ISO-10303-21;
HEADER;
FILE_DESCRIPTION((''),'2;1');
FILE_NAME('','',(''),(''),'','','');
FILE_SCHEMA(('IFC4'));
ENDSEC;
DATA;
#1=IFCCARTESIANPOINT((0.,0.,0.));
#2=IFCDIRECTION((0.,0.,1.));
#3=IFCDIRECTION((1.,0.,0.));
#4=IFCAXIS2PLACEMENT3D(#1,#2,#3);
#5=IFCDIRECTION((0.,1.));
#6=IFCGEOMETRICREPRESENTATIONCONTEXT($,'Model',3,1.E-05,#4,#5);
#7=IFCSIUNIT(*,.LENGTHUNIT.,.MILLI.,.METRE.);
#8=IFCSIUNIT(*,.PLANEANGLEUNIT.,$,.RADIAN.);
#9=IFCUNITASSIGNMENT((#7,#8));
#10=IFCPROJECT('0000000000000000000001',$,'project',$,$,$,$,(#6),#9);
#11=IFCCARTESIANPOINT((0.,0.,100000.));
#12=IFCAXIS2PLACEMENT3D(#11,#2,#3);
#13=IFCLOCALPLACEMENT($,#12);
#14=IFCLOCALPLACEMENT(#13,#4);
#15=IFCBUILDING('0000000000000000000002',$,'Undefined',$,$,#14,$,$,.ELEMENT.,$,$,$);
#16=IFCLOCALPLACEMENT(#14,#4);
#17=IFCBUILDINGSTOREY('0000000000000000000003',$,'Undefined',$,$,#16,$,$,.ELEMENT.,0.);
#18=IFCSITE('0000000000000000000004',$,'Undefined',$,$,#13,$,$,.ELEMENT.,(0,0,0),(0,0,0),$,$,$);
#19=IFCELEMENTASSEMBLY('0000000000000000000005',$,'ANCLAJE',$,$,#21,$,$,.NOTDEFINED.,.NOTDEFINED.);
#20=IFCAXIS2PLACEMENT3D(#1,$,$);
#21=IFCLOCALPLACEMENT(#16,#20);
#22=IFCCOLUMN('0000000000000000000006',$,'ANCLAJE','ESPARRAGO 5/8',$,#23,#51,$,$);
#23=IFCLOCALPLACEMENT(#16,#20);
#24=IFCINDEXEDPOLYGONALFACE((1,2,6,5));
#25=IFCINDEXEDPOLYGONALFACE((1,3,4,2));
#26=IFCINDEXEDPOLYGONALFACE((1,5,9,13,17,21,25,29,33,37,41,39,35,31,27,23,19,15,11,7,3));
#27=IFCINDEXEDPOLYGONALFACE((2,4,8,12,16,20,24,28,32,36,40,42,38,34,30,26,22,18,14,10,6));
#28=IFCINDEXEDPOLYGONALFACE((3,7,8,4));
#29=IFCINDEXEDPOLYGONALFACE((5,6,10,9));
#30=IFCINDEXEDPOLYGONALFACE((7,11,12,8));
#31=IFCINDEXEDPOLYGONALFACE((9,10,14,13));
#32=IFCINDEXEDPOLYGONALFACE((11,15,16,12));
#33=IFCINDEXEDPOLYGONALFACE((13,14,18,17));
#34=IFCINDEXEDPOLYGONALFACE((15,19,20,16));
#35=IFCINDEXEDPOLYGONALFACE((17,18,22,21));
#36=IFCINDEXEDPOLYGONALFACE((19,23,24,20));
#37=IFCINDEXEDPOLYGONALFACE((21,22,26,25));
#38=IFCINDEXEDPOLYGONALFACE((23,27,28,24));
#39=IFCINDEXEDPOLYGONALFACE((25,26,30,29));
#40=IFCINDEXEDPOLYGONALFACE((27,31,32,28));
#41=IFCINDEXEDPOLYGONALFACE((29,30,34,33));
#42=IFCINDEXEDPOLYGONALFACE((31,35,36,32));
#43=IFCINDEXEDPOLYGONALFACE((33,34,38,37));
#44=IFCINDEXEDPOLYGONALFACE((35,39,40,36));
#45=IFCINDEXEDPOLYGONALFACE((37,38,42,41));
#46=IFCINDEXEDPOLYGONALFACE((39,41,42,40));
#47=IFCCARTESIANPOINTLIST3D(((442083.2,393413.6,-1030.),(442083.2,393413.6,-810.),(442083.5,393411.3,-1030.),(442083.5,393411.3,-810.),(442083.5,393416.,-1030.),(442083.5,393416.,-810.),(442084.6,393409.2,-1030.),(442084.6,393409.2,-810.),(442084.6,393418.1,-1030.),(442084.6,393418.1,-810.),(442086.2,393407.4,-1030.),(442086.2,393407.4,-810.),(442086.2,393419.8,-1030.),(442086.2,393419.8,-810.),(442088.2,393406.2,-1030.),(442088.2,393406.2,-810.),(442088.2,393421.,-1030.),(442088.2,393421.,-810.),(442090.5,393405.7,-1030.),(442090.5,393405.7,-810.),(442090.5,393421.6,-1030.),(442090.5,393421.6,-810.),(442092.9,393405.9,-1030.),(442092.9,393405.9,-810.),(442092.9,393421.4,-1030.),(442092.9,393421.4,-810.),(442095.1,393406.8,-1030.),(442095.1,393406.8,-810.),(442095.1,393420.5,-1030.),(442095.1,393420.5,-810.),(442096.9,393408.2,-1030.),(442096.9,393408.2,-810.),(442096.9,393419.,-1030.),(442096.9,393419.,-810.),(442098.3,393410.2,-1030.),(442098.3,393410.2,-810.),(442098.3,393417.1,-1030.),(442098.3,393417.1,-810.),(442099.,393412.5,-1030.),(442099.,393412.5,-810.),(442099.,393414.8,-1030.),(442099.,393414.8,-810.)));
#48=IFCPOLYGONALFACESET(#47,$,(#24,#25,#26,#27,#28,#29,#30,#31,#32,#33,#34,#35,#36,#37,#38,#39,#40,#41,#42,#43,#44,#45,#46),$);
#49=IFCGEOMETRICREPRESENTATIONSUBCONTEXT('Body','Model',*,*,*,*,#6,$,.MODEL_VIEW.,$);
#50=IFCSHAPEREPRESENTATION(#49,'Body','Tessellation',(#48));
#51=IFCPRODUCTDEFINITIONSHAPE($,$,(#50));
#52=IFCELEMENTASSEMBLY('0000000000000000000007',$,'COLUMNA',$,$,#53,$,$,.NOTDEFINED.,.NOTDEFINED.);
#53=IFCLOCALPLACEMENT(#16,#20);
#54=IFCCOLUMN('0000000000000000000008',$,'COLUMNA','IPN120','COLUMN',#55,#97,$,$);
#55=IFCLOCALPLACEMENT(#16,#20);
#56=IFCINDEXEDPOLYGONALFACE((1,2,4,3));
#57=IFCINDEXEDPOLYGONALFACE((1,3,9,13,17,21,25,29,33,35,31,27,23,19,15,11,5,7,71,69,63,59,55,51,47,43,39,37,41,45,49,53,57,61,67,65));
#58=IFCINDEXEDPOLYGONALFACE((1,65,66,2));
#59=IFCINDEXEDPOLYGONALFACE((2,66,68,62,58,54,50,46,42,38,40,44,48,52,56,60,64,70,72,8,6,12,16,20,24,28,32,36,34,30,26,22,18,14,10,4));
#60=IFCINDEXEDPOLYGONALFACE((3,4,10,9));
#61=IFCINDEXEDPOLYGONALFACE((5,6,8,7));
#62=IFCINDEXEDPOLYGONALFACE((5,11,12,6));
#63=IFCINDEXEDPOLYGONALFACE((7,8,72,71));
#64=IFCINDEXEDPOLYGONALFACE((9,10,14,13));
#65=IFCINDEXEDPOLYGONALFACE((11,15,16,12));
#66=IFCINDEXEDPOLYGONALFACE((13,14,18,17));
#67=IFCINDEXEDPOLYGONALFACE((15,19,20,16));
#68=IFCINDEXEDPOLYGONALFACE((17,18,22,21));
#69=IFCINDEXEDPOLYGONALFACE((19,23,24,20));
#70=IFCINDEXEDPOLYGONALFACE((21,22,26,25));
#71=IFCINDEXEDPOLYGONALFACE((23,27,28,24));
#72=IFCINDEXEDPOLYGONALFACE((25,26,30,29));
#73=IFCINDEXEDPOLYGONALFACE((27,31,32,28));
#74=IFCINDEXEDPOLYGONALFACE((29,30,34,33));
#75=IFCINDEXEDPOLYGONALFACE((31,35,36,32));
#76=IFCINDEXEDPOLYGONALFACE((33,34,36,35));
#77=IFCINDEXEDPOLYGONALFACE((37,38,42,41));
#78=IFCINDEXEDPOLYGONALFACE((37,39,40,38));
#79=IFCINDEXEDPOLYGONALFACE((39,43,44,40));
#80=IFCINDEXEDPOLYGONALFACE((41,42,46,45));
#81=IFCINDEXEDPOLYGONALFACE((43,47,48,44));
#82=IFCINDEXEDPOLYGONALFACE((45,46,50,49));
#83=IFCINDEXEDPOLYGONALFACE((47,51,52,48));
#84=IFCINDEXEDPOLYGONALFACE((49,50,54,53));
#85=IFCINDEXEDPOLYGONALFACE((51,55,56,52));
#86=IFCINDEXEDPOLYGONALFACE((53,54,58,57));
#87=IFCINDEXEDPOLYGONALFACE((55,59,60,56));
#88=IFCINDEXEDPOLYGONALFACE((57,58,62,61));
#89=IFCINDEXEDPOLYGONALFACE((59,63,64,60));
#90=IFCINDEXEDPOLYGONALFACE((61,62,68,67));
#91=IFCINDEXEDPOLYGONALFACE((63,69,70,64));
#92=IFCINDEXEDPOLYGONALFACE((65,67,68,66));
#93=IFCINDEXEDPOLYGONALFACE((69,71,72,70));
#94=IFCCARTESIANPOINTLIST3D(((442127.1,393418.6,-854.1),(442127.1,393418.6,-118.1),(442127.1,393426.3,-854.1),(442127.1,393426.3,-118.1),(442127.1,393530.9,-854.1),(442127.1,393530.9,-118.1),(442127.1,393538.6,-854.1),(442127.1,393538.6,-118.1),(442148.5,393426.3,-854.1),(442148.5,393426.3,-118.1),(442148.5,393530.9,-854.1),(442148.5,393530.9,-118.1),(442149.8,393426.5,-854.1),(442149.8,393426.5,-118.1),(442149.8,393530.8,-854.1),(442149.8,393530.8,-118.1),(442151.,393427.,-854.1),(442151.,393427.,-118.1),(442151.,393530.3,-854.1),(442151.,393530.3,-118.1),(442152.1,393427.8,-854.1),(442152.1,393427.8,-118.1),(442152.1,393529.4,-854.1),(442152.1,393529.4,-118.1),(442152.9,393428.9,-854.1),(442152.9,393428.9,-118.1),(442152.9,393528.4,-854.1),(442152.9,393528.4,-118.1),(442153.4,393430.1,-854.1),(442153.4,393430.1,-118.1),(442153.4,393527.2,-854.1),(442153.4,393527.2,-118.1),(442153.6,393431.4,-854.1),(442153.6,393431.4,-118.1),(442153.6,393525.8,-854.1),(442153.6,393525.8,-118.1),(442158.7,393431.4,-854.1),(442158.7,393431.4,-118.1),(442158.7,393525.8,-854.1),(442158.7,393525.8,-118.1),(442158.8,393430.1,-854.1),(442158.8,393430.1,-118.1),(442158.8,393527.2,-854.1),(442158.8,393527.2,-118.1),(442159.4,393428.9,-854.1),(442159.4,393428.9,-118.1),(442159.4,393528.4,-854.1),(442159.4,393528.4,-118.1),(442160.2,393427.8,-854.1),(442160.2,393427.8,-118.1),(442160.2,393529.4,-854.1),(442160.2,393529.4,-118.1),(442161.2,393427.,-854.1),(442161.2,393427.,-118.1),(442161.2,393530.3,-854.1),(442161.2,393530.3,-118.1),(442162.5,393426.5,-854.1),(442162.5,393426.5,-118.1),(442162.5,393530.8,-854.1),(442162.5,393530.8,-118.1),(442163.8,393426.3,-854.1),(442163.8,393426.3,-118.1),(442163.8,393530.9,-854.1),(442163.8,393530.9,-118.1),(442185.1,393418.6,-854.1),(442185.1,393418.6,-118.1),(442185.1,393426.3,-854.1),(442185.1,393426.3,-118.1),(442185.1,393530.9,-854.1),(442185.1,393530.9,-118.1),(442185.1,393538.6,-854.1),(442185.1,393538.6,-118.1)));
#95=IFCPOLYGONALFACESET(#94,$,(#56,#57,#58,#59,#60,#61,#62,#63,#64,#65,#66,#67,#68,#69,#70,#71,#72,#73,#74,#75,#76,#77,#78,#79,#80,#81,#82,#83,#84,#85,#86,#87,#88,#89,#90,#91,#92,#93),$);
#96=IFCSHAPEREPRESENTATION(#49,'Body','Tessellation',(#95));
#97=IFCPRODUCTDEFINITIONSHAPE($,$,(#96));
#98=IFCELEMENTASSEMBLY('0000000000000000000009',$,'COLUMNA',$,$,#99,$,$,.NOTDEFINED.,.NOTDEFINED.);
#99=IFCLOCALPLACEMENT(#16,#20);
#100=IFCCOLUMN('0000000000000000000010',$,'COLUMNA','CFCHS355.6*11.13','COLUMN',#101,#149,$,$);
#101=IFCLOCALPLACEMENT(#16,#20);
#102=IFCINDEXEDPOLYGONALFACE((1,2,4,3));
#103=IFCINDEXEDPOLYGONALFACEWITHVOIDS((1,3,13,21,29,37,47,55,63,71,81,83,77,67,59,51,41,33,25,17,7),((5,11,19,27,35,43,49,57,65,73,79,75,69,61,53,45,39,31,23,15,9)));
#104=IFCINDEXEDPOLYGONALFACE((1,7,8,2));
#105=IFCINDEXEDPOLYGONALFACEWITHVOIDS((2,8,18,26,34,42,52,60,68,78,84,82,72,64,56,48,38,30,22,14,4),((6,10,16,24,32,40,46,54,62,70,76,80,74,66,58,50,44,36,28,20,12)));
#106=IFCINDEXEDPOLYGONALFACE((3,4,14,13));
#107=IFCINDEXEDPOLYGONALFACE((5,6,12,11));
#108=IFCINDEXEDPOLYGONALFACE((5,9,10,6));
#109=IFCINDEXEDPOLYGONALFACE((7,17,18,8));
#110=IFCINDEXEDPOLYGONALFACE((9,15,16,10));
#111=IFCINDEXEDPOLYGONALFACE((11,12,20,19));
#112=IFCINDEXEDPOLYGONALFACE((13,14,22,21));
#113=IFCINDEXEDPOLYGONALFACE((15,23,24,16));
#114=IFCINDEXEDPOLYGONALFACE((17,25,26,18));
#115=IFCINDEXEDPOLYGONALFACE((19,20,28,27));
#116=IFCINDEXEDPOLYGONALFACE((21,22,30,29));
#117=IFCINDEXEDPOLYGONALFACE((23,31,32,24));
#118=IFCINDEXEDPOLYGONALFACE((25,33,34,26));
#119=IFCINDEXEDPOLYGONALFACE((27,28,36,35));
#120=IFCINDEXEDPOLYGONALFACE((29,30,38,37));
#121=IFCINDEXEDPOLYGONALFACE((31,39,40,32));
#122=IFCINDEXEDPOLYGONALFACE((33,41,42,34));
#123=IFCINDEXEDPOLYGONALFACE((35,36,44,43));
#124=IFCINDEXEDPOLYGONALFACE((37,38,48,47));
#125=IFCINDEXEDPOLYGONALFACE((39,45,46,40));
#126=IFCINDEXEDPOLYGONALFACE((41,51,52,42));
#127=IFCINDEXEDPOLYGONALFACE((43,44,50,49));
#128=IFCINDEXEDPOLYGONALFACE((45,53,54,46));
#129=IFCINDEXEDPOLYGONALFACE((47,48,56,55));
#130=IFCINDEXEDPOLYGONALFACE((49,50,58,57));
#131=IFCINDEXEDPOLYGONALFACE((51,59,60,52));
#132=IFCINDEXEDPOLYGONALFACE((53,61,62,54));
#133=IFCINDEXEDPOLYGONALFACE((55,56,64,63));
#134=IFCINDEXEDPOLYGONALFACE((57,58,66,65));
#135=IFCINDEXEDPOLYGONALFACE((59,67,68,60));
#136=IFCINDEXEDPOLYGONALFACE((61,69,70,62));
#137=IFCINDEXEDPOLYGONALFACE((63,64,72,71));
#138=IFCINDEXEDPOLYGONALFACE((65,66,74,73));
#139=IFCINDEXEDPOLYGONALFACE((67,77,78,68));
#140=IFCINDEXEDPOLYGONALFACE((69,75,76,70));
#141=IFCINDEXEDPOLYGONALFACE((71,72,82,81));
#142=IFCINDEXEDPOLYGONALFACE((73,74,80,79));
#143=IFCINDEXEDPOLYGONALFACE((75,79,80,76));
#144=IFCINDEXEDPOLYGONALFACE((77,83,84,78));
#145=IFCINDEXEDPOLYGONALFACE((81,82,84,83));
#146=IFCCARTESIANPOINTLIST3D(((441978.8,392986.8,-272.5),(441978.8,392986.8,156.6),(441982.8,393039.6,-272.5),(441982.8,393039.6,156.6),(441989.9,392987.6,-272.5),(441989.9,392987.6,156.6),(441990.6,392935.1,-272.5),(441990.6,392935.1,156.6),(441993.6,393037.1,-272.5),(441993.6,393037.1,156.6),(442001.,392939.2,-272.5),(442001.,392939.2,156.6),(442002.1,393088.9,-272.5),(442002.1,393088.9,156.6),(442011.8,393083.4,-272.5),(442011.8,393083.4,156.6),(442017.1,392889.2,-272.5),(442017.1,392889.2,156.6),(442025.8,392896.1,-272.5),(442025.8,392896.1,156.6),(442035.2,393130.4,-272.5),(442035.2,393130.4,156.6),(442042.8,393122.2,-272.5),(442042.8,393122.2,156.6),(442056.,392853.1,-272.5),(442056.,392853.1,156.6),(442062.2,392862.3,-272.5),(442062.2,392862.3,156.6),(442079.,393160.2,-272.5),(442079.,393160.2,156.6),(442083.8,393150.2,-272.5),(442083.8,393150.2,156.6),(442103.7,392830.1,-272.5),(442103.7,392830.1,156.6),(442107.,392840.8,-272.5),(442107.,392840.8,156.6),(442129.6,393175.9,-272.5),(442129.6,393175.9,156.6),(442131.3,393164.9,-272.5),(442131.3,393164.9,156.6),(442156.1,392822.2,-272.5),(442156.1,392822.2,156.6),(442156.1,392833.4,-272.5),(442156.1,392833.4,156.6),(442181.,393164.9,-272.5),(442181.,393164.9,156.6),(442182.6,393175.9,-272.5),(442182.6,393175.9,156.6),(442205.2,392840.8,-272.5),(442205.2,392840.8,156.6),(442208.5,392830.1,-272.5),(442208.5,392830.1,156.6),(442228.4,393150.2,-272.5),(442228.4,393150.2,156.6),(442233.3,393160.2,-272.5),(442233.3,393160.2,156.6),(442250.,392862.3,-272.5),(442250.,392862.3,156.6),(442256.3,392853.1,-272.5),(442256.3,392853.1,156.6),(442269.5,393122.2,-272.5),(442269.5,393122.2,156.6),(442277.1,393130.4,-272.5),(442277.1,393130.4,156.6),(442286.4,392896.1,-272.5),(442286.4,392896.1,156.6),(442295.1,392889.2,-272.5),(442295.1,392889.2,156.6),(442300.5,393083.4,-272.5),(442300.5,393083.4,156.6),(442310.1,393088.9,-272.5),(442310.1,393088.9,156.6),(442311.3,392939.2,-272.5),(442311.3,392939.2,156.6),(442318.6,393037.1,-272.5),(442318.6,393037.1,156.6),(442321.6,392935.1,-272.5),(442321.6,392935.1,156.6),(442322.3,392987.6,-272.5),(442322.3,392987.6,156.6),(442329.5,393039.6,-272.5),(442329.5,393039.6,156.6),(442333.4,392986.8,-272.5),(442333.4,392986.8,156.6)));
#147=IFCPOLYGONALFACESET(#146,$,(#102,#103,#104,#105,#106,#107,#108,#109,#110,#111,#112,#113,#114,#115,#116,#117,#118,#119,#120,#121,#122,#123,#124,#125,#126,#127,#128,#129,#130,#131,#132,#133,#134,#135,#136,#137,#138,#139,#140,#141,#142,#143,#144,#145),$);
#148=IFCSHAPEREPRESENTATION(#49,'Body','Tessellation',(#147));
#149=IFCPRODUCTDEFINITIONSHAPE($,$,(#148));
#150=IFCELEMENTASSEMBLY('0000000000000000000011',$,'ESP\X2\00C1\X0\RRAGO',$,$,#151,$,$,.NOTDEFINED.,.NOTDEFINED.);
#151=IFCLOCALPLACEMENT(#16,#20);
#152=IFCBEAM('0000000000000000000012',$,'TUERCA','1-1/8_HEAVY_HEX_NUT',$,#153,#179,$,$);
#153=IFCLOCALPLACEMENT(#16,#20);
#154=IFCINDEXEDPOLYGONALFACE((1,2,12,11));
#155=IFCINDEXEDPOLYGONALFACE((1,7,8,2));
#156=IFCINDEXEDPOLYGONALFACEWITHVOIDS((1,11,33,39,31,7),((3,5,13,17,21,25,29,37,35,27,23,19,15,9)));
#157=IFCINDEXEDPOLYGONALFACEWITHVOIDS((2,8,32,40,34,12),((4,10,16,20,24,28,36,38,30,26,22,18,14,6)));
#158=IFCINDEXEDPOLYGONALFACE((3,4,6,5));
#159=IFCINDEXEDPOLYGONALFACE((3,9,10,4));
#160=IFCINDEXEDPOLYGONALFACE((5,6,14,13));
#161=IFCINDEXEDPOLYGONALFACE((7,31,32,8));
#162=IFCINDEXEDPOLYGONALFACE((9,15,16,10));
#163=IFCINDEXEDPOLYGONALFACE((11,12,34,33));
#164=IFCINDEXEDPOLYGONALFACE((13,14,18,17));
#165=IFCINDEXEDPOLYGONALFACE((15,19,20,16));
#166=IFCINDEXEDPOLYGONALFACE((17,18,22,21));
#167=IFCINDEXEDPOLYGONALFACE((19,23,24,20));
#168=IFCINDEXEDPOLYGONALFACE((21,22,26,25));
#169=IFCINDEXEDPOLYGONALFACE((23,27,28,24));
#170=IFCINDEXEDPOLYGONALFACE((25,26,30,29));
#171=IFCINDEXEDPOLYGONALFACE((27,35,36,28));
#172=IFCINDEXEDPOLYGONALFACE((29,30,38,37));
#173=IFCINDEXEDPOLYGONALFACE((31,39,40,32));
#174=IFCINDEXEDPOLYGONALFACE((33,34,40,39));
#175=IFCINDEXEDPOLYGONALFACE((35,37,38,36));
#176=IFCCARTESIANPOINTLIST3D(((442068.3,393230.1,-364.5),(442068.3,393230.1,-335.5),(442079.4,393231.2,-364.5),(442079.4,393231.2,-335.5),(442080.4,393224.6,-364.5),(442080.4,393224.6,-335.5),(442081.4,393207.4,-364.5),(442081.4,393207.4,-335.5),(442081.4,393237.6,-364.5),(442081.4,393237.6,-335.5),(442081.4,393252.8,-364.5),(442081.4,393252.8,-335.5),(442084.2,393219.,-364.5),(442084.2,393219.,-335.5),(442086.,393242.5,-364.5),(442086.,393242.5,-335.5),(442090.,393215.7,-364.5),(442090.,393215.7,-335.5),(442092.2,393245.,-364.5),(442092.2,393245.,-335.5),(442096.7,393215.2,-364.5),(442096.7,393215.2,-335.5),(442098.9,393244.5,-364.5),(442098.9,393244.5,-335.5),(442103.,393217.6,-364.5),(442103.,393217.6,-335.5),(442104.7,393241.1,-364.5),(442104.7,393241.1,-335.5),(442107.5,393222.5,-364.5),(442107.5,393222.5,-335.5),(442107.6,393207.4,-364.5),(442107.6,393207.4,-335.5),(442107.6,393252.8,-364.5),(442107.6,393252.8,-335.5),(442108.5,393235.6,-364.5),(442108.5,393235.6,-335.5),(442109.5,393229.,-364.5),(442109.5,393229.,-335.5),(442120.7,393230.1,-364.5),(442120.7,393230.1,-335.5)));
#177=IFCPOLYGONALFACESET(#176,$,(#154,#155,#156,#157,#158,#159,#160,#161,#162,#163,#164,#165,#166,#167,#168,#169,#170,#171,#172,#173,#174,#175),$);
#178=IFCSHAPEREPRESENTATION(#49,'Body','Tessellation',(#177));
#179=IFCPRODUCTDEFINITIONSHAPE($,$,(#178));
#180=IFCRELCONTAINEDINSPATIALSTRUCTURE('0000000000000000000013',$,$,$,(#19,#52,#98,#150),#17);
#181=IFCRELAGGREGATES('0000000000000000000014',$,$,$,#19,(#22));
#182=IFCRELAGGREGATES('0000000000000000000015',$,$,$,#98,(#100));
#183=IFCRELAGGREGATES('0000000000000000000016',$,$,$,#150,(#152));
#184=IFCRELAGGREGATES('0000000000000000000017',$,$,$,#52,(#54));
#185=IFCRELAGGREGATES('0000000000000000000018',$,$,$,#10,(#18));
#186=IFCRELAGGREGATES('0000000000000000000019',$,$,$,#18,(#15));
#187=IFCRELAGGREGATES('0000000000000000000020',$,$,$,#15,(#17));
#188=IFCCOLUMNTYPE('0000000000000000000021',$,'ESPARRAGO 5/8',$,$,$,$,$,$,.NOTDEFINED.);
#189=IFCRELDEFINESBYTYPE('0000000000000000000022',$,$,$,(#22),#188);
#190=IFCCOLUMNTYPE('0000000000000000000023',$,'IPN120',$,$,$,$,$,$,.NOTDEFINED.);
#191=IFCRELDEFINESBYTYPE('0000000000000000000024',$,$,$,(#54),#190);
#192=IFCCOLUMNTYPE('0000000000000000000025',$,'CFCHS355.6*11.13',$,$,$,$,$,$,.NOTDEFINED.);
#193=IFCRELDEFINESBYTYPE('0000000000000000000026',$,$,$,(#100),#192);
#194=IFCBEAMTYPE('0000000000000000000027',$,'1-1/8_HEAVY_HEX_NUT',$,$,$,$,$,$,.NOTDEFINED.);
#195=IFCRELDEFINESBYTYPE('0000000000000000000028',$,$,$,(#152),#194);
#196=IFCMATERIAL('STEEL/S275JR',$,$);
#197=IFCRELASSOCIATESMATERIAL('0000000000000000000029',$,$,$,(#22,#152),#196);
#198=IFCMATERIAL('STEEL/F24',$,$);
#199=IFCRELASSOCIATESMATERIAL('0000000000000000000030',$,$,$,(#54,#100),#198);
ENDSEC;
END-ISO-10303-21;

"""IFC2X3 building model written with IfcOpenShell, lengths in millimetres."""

from ifc_helpers import new_model, si_unit, direction, frame, origin_with_axes, origin_2d_with_axis, place, context, subcontext, project, spatial, polyline, circle, hollow_circle, i_section, outline, extrude, clip, halfspace, material, type_object, element, aggregate, save


model = new_model("IFC2X3")

# Units and contexts
model_context = context("Model", 3, precision=1e-05, world=origin_with_axes(), true_north=direction((0.0, 1.0)))
body_context = subcontext(model_context, "Body", "Model", "MODEL_VIEW")
ifc_project = project(units=[si_unit("LENGTHUNIT", "METRE", prefix="MILLI"), si_unit("PLANEANGLEUNIT", "RADIAN")], contexts=[model_context])

# Site, building, storey
site_placement = place(None, frame((0.0, 0.0, 100000.0), z_axis=(0.0, 0.0, 1.0), x_axis=(1.0, 0.0, 0.0)))
site = spatial("IfcSite", under=ifc_project, at=site_placement, Name="Undefined", CompositionType="ELEMENT", RefLatitude=(0, 0, 0), RefLongitude=(0, 0, 0))
building_placement = place(site_placement, origin_with_axes())
building = spatial("IfcBuilding", under=site, at=building_placement, Name="Undefined", CompositionType="ELEMENT")
storey_placement = place(building_placement, origin_with_axes())
storey = spatial("IfcBuildingStorey", under=building, at=storey_placement, Name="Undefined", CompositionType="ELEMENT", Elevation=0.0)

# Element assembly
ifc_material_1 = material(Name="STEEL/S275JR")
assembly_1_placement = place(storey_placement, origin_with_axes())
assembly_1 = element("IfcElementAssembly", 1, at=assembly_1_placement, inside=storey, Name="ANCLAJE", AssemblyPlace="NOTDEFINED", PredefinedType="NOTDEFINED")

# Column
column_type_1 = type_object("IfcColumnType", Name="ESPARRAGO 5/8", PredefinedType="NOTDEFINED")
column_1_placement = place(assembly_1_placement, frame((442091.1, 393413.6, -810.0), z_axis=(0.0, 0.0, -1.0), x_axis=(0.0, -1.0, 0.0)))
column_1 = element("IfcColumn", 2, at=column_1_placement, type_object=column_type_1, material=ifc_material_1, Name="ANCLAJE", Description="ESPARRAGO 5/8", context=body_context, shape_type="SweptSolid", body=[
    extrude(circle(Radius=7.9, at=origin_2d_with_axis()), frame((0.0, 0.0, 220.0), z_axis=(0.0, 0.0, -1.0), x_axis=(0.0, 1.0, 0.0)), (0.0, 0.0, 1.0), 220.0),
])
aggregate(assembly_1, [column_1])

# Element assemblies, columns
assembly_2_placement = place(storey_placement, origin_with_axes())
assembly_2 = element("IfcElementAssembly", 3, at=assembly_2_placement, inside=storey, Name="COLUMNA", AssemblyPlace="NOTDEFINED", PredefinedType="NOTDEFINED")
ifc_material_2 = material(Name="STEEL/F24")
column_type_2 = type_object("IfcColumnType", Name="IPN120", PredefinedType="NOTDEFINED")
column_2_placement = place(assembly_2_placement, frame((442156.1, 393478.6, -880.0), z_axis=(0.0, 0.0, 1.0), x_axis=(0.0, -1.0, 0.0)))
column_2 = element("IfcColumn", 4, at=column_2_placement, type_object=column_type_2, material=ifc_material_2, Name="COLUMNA", Description="IPN120", ObjectType="COLUMN", context=body_context, shape_type="Clipping", body=[
    clip(extrude(i_section(OverallWidth=58.0, OverallDepth=120.0, WebThickness=5.1, FlangeThickness=7.7, FilletRadius=5.1, at=origin_2d_with_axis()), frame((0.0, 0.0, 761.9), z_axis=(0.0, 0.0, -1.0), x_axis=(0.0, 1.0, 0.0)), (0.0, 0.0, 1.0), 761.9), halfspace(frame((-60.0, 0.0, 25.9), z_axis=(0.0, 0.0, 1.0), x_axis=(0.0, 1.0, 0.0)), True)),
])
assembly_3_placement = place(storey_placement, origin_with_axes())
assembly_3 = element("IfcElementAssembly", 5, at=assembly_3_placement, inside=storey, Name="COLUMNA", AssemblyPlace="NOTDEFINED", PredefinedType="NOTDEFINED")
column_type_3 = type_object("IfcColumnType", Name="CFCHS355.6*11.13", PredefinedType="NOTDEFINED")
column_3_placement = place(assembly_3_placement, frame((442156.1, 393000.0, -272.5), z_axis=(0.0, 0.0, 1.0), x_axis=(-1.0, 0.0, 0.0)))
column_3 = element("IfcColumn", 6, at=column_3_placement, type_object=column_type_3, material=ifc_material_2, Name="COLUMNA", Description="CFCHS355.6*11.13", ObjectType="COLUMN", context=body_context, shape_type="SweptSolid", body=[
    extrude(hollow_circle(Radius=177.8, WallThickness=11.1, at=origin_2d_with_axis()), frame((0.0, 0.0, 429.1), z_axis=(0.0, 0.0, -1.0), x_axis=(0.0, 1.0, 0.0)), (0.0, 0.0, 1.0), 429.1),
])
aggregate(assembly_3, [column_3])

# Element assembly, beam
assembly_4_placement = place(storey_placement, origin_with_axes())
assembly_4 = element("IfcElementAssembly", 7, at=assembly_4_placement, inside=storey, Name="ESPÁRRAGO", AssemblyPlace="NOTDEFINED", PredefinedType="NOTDEFINED")
beam_type_1 = type_object("IfcBeamType", Name="1-1/8_HEAVY_HEX_NUT", PredefinedType="NOTDEFINED")
beam_1_placement = place(assembly_4_placement, frame((442094.5, 393230.1, -335.5), z_axis=(0.866025, -0.5, 0.0), x_axis=(0.0, 0.0, -1.0)))
beam_1 = element("IfcBeam", 8, at=beam_1_placement, type_object=beam_type_1, material=ifc_material_1, Name="TUERCA", Description="1-1/8_HEAVY_HEX_NUT", context=body_context, shape_type="SweptSolid", body=[
    extrude(outline(polyline([(-13.1, -22.7), (-26.2, 0.0), (-13.1, 22.7), (13.1, 22.7), (26.2, 0.0), (13.1, -22.7), (-13.1, -22.7)]), holes=[polyline([(6.5, 13.6), (0.0, 15.1), (-6.5, 13.6), (-11.8, 9.4), (-14.7, 3.4), (-14.7, -3.4), (-11.8, -9.4), (-6.5, -13.6), (0.0, -15.1), (6.5, -13.6), (11.8, -9.4), (14.7, -3.4), (14.7, 3.4), (11.8, 9.4), (6.5, 13.6)])]), frame((29.0, 0.0, 0.0), z_axis=(-1.0, 0.0, 0.0), x_axis=(0.0, -1.0, 0.0)), (0.0, 0.0, 1.0), 29.0),
])

aggregate(assembly_4, [beam_1])

aggregate(assembly_2, [column_2])

save(model, "model.ifc")
